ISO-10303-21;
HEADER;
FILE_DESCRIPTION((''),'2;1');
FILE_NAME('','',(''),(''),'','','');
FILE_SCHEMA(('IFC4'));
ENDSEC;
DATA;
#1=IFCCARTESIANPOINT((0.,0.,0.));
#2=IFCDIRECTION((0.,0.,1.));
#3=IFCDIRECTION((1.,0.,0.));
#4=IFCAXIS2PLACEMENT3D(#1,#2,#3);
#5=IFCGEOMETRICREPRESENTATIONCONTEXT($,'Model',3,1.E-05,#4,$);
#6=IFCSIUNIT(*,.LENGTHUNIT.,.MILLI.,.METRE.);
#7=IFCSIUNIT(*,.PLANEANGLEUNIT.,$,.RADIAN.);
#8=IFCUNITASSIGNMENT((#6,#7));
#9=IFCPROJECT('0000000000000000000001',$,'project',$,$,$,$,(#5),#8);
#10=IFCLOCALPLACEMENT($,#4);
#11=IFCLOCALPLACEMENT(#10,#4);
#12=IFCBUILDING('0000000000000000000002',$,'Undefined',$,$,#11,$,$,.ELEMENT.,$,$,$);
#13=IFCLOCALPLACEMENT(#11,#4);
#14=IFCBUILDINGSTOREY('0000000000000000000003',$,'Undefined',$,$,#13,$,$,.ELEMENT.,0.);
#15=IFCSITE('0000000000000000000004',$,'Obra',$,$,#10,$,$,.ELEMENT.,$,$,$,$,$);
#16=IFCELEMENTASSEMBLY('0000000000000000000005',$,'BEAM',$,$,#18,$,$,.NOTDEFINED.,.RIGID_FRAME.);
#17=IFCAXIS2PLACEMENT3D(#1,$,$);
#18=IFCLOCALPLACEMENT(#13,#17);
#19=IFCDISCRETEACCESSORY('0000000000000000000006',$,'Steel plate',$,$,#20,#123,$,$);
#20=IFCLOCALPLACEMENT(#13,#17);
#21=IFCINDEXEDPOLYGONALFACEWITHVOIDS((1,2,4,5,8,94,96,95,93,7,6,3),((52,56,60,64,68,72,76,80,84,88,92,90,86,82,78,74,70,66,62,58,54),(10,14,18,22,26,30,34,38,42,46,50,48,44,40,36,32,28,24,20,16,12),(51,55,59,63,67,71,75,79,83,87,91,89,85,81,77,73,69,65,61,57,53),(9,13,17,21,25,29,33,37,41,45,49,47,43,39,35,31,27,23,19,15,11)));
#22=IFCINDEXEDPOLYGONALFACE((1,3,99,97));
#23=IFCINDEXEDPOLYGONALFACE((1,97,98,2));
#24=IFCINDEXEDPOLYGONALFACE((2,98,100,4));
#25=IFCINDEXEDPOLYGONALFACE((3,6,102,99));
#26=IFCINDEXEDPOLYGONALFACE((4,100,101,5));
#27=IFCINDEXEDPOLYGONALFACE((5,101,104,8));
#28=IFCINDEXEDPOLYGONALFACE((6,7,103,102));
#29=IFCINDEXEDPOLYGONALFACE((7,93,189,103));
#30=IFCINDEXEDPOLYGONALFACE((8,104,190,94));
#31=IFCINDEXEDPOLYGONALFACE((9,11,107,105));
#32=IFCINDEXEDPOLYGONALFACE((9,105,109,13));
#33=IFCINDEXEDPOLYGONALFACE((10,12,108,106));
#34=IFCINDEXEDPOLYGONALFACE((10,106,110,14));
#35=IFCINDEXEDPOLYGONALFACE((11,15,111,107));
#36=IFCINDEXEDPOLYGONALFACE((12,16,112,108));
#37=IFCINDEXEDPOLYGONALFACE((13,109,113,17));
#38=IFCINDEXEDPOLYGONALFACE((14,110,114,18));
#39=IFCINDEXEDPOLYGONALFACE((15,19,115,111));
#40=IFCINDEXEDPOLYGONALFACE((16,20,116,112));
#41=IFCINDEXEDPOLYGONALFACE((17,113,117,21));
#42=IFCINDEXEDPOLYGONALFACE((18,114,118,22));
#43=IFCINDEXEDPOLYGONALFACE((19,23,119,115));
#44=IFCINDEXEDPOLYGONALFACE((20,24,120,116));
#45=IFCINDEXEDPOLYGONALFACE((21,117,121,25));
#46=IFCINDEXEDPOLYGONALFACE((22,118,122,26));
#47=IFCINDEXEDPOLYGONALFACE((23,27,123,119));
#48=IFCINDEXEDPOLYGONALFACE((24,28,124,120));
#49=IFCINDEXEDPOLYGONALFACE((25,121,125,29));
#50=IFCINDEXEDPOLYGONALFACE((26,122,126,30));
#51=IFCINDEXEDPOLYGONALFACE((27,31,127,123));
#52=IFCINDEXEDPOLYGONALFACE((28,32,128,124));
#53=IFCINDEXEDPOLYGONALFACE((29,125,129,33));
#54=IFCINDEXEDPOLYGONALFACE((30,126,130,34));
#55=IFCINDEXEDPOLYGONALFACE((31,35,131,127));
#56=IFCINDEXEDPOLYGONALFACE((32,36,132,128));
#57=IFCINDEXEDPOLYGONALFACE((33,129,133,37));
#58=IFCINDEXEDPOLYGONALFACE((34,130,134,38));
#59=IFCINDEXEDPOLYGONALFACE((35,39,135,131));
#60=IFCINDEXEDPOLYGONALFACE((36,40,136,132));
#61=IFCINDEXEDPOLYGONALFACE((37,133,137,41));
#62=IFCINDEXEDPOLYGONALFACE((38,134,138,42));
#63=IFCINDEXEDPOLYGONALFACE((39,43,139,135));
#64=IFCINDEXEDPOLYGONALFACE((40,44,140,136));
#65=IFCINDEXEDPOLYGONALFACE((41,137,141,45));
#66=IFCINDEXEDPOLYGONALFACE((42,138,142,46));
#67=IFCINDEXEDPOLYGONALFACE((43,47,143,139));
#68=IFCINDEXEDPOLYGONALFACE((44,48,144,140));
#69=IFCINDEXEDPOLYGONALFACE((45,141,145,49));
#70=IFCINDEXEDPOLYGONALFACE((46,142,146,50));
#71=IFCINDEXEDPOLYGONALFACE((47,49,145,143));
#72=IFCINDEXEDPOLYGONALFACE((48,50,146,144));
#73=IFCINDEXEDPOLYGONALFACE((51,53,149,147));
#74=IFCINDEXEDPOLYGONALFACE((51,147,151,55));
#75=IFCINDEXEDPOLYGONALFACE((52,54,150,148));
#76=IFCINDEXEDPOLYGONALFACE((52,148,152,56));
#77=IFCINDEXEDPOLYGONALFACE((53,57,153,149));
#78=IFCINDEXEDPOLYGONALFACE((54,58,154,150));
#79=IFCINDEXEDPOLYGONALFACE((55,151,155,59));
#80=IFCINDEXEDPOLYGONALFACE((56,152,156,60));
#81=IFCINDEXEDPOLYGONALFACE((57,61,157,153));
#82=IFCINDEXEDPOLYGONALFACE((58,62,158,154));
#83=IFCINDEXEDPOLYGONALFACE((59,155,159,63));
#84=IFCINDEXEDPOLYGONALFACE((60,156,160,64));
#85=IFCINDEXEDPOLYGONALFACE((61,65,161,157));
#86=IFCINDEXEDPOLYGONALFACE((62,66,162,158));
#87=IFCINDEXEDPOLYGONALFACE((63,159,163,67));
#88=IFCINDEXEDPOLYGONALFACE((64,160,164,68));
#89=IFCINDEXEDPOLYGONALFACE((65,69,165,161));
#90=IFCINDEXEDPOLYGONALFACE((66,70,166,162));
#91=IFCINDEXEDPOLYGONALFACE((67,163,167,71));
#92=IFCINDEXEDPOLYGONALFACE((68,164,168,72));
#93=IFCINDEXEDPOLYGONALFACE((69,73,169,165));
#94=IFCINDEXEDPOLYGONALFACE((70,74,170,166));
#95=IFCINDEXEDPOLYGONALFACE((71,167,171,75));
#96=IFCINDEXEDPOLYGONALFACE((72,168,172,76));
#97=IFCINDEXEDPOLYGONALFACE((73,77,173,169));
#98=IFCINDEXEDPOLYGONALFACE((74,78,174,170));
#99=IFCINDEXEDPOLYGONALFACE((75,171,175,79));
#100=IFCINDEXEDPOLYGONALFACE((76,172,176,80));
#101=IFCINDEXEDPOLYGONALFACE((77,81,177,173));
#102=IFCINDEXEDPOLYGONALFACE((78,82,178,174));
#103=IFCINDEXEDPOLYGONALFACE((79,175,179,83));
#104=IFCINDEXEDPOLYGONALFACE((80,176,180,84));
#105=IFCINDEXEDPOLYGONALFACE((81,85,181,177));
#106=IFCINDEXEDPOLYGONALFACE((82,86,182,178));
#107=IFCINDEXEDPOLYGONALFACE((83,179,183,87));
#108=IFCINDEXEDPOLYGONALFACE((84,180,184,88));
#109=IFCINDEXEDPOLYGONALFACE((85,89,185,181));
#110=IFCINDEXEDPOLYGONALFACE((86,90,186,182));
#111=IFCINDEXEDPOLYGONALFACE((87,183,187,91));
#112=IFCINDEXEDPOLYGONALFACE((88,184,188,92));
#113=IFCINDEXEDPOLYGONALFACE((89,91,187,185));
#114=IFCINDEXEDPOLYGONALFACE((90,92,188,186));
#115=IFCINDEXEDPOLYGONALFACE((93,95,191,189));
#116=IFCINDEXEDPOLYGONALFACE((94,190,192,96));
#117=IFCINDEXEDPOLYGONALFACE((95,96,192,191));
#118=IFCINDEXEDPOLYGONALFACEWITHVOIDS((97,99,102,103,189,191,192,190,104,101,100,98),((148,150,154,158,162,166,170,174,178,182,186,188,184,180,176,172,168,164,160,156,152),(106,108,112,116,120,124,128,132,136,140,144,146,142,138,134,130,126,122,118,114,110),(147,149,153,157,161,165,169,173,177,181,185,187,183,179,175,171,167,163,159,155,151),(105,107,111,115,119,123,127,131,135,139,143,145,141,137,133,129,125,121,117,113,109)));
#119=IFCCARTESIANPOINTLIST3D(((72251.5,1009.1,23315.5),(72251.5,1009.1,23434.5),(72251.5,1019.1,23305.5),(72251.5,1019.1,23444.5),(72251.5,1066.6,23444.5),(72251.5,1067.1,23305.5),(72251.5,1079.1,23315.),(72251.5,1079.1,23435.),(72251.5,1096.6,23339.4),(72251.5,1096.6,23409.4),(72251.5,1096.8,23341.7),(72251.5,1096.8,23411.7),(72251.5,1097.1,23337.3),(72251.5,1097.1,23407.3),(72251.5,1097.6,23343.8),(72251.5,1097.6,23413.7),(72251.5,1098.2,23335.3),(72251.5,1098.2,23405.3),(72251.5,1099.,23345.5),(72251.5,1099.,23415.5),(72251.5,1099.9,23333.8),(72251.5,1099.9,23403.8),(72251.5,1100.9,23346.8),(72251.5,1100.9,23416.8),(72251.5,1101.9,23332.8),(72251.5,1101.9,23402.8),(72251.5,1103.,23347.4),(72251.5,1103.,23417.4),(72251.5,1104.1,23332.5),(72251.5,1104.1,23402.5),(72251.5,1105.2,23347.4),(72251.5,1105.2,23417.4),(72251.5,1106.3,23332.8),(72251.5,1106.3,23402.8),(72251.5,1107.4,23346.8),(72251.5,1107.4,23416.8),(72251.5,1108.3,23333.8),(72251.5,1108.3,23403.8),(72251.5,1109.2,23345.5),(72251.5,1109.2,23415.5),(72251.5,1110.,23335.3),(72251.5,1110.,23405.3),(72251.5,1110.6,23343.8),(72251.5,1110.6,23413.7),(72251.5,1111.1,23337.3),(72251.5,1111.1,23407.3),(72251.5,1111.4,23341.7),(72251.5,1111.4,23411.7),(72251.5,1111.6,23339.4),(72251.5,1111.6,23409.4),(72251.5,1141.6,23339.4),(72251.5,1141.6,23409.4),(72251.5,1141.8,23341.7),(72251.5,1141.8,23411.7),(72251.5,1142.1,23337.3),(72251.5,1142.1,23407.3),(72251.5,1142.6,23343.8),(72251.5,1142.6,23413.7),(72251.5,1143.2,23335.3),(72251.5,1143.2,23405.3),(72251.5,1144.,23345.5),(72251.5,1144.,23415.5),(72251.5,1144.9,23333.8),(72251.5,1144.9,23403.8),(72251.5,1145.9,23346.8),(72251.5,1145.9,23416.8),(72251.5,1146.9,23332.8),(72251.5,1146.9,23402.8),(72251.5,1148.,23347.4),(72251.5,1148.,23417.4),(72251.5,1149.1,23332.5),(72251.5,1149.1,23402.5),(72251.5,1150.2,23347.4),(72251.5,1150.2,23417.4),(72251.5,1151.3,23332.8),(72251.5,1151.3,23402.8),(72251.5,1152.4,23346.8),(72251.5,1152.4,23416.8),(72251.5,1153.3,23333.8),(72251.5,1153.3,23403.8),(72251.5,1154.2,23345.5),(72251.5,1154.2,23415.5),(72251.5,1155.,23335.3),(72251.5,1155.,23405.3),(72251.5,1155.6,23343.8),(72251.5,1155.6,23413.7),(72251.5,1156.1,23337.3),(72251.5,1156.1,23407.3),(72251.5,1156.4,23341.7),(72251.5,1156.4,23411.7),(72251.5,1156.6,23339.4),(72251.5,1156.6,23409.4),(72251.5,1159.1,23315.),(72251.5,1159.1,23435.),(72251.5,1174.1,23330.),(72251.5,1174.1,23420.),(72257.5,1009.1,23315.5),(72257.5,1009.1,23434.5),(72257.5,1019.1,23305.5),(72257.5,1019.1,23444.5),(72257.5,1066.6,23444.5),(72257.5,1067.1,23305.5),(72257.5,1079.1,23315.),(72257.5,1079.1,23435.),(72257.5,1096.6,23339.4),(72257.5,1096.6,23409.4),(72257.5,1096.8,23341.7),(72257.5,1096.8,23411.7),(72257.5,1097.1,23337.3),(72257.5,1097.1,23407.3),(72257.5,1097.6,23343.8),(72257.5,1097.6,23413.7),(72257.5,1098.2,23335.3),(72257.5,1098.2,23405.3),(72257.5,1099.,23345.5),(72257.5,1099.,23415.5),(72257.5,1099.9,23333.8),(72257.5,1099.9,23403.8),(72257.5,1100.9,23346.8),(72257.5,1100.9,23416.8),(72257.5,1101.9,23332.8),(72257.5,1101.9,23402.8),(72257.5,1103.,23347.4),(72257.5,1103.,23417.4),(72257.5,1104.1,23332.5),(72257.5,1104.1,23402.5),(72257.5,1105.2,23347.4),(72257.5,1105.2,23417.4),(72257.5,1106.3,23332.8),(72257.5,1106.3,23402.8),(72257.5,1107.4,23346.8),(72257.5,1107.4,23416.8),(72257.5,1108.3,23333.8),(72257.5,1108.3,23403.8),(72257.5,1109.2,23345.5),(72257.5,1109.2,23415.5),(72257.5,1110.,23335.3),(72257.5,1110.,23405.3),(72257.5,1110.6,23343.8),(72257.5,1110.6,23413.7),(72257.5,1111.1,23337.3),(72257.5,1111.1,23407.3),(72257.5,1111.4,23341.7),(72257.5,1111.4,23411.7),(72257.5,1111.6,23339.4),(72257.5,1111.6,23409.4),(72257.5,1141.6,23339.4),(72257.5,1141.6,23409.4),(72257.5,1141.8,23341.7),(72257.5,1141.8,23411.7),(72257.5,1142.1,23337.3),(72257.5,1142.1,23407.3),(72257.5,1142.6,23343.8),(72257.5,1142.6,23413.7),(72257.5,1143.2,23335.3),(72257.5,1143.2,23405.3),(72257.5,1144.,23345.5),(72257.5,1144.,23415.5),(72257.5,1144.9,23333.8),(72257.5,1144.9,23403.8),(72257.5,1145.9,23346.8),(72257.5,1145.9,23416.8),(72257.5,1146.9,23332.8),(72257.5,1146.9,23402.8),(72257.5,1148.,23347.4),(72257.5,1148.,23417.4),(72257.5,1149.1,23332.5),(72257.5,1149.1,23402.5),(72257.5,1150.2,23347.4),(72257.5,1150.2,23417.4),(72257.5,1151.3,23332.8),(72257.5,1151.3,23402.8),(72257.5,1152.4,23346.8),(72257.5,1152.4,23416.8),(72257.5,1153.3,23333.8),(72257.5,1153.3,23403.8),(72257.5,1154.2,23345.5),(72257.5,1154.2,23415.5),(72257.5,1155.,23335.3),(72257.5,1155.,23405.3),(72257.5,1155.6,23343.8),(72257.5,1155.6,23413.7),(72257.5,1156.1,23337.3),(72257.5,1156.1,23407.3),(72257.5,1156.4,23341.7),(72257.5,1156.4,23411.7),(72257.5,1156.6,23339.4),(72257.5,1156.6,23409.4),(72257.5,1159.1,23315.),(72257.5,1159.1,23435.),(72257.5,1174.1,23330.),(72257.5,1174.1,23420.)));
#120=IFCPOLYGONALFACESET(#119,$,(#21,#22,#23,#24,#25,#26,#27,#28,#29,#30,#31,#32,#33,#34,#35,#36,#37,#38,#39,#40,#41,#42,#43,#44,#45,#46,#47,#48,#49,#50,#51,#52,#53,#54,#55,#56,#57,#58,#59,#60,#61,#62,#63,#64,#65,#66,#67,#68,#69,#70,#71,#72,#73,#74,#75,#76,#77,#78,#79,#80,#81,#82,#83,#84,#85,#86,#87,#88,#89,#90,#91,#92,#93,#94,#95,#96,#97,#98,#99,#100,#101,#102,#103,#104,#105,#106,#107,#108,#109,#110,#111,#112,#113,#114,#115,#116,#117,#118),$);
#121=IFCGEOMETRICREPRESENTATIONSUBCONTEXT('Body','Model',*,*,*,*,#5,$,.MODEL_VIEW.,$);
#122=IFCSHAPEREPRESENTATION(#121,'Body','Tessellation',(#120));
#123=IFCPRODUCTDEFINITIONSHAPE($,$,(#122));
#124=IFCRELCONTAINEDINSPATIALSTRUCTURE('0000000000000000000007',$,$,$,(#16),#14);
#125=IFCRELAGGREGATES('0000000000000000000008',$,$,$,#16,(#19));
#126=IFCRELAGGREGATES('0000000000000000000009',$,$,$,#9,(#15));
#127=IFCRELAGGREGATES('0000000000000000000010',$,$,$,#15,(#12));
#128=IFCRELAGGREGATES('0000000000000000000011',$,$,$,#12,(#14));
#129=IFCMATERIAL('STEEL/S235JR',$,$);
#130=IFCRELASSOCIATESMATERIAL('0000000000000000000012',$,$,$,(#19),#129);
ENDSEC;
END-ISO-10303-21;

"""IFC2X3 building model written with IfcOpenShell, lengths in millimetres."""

from ifc_helpers import new_model, si_unit, frame, origin_with_axes, origin_2d_with_axis, place, context, subcontext, project, spatial, polyline, circle, outline, extrude, source, transform, mapped, material, element, aggregate, save


model = new_model("IFC2X3")

# Units and contexts
model_context = context("Model", 3, precision=1e-05, world=origin_with_axes())
body_context = subcontext(model_context, "Body", "Model", "MODEL_VIEW")
ifc_project = project(units=[si_unit("LENGTHUNIT", "METRE", prefix="MILLI"), si_unit("PLANEANGLEUNIT", "RADIAN")], contexts=[model_context])

# Site, building, storey
site_placement = place(None, origin_with_axes())
site = spatial("IfcSite", under=ifc_project, at=site_placement, Name="Obra", CompositionType="ELEMENT")
building_placement = place(site_placement, origin_with_axes())
building = spatial("IfcBuilding", under=site, at=building_placement, Name="Undefined", CompositionType="ELEMENT")
storey_placement = place(building_placement, origin_with_axes())
storey = spatial("IfcBuildingStorey", under=building, at=storey_placement, Name="Undefined", CompositionType="ELEMENT", Elevation=0.0)

# Shared definitions
ifc_material_1 = material(Name="STEEL/S235JR")

# Element assembly
assembly_1_placement = place(storey_placement, origin_with_axes())
assembly_1 = element("IfcElementAssembly", 1, at=assembly_1_placement, inside=storey, Name="BEAM", AssemblyPlace="NOTDEFINED", PredefinedType="RIGID_FRAME")

# Discrete accessory, opening
discrete_accessory_1_placement = place(assembly_1_placement, frame((72254.5, 1009.1, 23315.5), z_axis=(1.0, 0.0, 0.0), x_axis=(0.0, 0.707107, -0.707107)))
discrete_accessory_1 = element("IfcDiscreteAccessory", 2, at=discrete_accessory_1_placement, material=ifc_material_1, Name="Steel plate", context=body_context, shape_type="SweptSolid", body=[
    extrude(outline(polyline([(0.0, 0.0), (14.1, 0.0), (48.1, 33.9), (49.9, 49.1), (106.4, 105.7), (106.4, 126.9), (42.8, 190.6), (21.6, 190.6), (-35.0, 134.0), (-50.6, 131.9), (-84.1, 98.3), (-84.1, 84.1), (0.0, 0.0)])), frame((0.0, 0.0, -3.0), z_axis=(0.0, 0.0, 1.0), x_axis=(1.0, 0.0, 0.0)), (0.0, 0.0, 1.0), 6.0),
])
shared_shape_1 = source(origin_with_axes(), body_context, "Body", "SweptSolid", [
    extrude(circle(Radius=7.5, at=origin_2d_with_axis()), frame((0.0, 2.4, 0.0), z_axis=(0.0, 1.0, 0.0), x_axis=(1.0, 0.0, 0.0)), (0.0, 0.0, 1.0), 6.2),
])
opening_1_placement = place(assembly_1_placement, frame((72260.0, 1126.6, 23410.0), z_axis=(0.0, 1.0, 0.0), x_axis=(0.0, 0.0, -1.0)))
element("IfcOpeningElement", 3, at=opening_1_placement, cuts=discrete_accessory_1, ObjectType="Opening", context=body_context, shape_type="MappedRepresentation", body=[
    mapped(shared_shape_1, transform((0.0, 0.0, -22.5))),
    mapped(shared_shape_1, transform((70.0, 0.0, -22.5))),
    mapped(shared_shape_1, transform((0.0, 0.0, 22.5))),
    mapped(shared_shape_1, transform((70.0, 0.0, 22.5))),
])
aggregate(assembly_1, [discrete_accessory_1])

save(model, "model.ifc")
